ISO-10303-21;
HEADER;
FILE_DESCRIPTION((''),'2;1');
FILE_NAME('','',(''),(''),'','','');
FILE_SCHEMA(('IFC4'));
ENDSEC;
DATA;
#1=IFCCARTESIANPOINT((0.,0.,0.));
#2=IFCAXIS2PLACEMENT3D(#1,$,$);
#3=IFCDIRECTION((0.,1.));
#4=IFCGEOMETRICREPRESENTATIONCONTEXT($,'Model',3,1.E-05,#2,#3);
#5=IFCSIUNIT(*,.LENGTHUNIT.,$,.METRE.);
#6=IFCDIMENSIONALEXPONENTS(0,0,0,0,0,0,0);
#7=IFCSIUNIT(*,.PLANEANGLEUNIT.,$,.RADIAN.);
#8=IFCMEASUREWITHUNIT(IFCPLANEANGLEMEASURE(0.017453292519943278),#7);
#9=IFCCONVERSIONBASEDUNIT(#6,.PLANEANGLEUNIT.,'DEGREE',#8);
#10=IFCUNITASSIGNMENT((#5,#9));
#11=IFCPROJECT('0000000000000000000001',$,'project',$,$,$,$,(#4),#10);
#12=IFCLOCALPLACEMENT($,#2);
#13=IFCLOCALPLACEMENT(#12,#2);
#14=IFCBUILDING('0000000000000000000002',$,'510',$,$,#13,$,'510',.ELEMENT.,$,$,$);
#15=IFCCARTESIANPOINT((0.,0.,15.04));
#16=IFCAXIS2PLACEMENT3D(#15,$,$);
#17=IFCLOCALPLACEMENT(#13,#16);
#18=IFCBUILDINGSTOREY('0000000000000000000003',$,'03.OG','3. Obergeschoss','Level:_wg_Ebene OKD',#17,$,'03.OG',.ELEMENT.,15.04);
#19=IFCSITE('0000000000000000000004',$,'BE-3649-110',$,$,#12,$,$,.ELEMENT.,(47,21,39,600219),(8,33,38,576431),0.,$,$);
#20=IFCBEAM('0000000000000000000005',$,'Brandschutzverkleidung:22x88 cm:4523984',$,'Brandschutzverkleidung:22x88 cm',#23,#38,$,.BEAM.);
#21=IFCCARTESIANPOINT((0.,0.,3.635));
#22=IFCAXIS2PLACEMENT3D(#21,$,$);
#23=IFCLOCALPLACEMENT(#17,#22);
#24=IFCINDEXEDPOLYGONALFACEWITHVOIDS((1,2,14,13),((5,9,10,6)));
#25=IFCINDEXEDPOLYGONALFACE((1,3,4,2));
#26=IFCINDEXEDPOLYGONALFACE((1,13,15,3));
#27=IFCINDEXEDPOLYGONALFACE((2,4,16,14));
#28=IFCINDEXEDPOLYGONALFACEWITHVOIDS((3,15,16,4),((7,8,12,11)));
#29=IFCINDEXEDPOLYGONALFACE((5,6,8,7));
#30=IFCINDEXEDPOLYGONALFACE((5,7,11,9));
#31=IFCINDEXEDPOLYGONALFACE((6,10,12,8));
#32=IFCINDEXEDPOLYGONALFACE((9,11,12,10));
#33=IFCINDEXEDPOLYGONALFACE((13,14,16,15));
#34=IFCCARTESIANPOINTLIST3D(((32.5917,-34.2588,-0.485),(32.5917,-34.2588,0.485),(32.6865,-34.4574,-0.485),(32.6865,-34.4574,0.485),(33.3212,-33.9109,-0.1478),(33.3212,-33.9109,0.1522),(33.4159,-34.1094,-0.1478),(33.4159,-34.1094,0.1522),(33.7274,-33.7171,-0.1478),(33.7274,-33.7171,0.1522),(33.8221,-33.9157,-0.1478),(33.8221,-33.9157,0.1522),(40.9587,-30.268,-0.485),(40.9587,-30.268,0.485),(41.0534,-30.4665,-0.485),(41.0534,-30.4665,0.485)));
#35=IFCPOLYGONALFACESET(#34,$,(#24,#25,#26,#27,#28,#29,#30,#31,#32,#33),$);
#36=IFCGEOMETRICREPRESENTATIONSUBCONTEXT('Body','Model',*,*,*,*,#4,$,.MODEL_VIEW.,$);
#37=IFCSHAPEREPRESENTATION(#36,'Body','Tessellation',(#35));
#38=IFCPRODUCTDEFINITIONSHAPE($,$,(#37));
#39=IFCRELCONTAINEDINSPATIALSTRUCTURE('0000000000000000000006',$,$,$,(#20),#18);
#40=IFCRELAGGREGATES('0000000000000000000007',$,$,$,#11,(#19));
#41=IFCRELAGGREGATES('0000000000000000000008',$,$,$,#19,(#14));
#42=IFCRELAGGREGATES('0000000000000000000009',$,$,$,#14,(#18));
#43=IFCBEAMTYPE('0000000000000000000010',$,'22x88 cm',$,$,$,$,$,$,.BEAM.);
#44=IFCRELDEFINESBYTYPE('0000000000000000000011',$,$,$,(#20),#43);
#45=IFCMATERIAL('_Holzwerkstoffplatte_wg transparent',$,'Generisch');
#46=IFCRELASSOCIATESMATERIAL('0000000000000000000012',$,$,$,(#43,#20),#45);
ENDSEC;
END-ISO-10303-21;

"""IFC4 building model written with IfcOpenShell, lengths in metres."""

from ifc_helpers import new_model, entity, si_unit, converted_unit, direction, frame, origin, place, context, subcontext, project, spatial, indexed_curve, outline, extrude, source, transform, mapped, material, type_object, type_shapes, element, save


model = new_model("IFC4")

# Units and contexts
model_context = context("Model", 3, precision=1e-05, world=origin(), true_north=direction((0.0, 1.0)))
body_context = subcontext(model_context, "Body", "Model", "MODEL_VIEW")
ifc_project = project(units=[si_unit("LENGTHUNIT", "METRE"), converted_unit("PLANEANGLEUNIT", "DEGREE", entity("IfcPlaneAngleMeasure", 0.017453292519943278), si_unit("PLANEANGLEUNIT", "RADIAN"), dimensions=[0, 0, 0, 0, 0, 0, 0])], contexts=[model_context])

# Site, building, storey
site_placement = place(None, origin())
site = spatial("IfcSite", under=ifc_project, at=site_placement, Name="BE-3649-110", CompositionType="ELEMENT", RefLatitude=(47, 21, 39, 600219), RefLongitude=(8, 33, 38, 576431), RefElevation=0.0)
building_placement = place(site_placement, origin())
building = spatial("IfcBuilding", under=site, at=building_placement, Name="510", LongName="510", CompositionType="ELEMENT")
storey_placement = place(building_placement, frame((0.0, 0.0, 15.04)))
storey = spatial("IfcBuildingStorey", under=building, at=storey_placement, Name="03.OG", Description="3. Obergeschoss", ObjectType="Level:_wg_Ebene OKD", LongName="03.OG", CompositionType="ELEMENT", Elevation=15.04)

# Beam
ifc_material_1 = material(Name="_Holzwerkstoffplatte_wg transparent", Category="Generisch")
beam_type_1 = type_object("IfcBeamType", Name="22x88 cm", PredefinedType="BEAM", material=ifc_material_1)
shared_shape_1 = source(origin(), body_context, "Body", "SweptSolid", [
    extrude(outline(indexed_curve([(-4.635, -0.485), (4.635, -0.485), (4.635, 0.485), (-4.635, 0.485), (-4.635, -0.485)], self_intersect=False), holes=[indexed_curve([(3.3768, -0.1478), (3.3768, 0.1522), (3.8268, 0.1522), (3.8268, -0.1478), (3.3768, -0.1478)], self_intersect=False)]), frame((36.8699, -32.462, 0.0), z_axis=(-0.430511, 0.902585, 0.0), x_axis=(-0.902585, -0.430511, 0.0)), (0.0, 0.0, 1.0), 0.22),
])
type_shapes(beam_type_1, [shared_shape_1])
beam_1_placement = place(storey_placement, frame((0.0, 0.0, 3.635)))
element("IfcBeam", 1, at=beam_1_placement, inside=storey, type_object=beam_type_1, material=ifc_material_1, Name="Brandschutzverkleidung:22x88 cm:4523984", ObjectType="Brandschutzverkleidung:22x88 cm", PredefinedType="BEAM", context=body_context, shape_type="MappedRepresentation", body=[
    mapped(shared_shape_1, transform((0.0, 0.0, 0.0), scale=1.0)),
])

save(model, "model.ifc")
